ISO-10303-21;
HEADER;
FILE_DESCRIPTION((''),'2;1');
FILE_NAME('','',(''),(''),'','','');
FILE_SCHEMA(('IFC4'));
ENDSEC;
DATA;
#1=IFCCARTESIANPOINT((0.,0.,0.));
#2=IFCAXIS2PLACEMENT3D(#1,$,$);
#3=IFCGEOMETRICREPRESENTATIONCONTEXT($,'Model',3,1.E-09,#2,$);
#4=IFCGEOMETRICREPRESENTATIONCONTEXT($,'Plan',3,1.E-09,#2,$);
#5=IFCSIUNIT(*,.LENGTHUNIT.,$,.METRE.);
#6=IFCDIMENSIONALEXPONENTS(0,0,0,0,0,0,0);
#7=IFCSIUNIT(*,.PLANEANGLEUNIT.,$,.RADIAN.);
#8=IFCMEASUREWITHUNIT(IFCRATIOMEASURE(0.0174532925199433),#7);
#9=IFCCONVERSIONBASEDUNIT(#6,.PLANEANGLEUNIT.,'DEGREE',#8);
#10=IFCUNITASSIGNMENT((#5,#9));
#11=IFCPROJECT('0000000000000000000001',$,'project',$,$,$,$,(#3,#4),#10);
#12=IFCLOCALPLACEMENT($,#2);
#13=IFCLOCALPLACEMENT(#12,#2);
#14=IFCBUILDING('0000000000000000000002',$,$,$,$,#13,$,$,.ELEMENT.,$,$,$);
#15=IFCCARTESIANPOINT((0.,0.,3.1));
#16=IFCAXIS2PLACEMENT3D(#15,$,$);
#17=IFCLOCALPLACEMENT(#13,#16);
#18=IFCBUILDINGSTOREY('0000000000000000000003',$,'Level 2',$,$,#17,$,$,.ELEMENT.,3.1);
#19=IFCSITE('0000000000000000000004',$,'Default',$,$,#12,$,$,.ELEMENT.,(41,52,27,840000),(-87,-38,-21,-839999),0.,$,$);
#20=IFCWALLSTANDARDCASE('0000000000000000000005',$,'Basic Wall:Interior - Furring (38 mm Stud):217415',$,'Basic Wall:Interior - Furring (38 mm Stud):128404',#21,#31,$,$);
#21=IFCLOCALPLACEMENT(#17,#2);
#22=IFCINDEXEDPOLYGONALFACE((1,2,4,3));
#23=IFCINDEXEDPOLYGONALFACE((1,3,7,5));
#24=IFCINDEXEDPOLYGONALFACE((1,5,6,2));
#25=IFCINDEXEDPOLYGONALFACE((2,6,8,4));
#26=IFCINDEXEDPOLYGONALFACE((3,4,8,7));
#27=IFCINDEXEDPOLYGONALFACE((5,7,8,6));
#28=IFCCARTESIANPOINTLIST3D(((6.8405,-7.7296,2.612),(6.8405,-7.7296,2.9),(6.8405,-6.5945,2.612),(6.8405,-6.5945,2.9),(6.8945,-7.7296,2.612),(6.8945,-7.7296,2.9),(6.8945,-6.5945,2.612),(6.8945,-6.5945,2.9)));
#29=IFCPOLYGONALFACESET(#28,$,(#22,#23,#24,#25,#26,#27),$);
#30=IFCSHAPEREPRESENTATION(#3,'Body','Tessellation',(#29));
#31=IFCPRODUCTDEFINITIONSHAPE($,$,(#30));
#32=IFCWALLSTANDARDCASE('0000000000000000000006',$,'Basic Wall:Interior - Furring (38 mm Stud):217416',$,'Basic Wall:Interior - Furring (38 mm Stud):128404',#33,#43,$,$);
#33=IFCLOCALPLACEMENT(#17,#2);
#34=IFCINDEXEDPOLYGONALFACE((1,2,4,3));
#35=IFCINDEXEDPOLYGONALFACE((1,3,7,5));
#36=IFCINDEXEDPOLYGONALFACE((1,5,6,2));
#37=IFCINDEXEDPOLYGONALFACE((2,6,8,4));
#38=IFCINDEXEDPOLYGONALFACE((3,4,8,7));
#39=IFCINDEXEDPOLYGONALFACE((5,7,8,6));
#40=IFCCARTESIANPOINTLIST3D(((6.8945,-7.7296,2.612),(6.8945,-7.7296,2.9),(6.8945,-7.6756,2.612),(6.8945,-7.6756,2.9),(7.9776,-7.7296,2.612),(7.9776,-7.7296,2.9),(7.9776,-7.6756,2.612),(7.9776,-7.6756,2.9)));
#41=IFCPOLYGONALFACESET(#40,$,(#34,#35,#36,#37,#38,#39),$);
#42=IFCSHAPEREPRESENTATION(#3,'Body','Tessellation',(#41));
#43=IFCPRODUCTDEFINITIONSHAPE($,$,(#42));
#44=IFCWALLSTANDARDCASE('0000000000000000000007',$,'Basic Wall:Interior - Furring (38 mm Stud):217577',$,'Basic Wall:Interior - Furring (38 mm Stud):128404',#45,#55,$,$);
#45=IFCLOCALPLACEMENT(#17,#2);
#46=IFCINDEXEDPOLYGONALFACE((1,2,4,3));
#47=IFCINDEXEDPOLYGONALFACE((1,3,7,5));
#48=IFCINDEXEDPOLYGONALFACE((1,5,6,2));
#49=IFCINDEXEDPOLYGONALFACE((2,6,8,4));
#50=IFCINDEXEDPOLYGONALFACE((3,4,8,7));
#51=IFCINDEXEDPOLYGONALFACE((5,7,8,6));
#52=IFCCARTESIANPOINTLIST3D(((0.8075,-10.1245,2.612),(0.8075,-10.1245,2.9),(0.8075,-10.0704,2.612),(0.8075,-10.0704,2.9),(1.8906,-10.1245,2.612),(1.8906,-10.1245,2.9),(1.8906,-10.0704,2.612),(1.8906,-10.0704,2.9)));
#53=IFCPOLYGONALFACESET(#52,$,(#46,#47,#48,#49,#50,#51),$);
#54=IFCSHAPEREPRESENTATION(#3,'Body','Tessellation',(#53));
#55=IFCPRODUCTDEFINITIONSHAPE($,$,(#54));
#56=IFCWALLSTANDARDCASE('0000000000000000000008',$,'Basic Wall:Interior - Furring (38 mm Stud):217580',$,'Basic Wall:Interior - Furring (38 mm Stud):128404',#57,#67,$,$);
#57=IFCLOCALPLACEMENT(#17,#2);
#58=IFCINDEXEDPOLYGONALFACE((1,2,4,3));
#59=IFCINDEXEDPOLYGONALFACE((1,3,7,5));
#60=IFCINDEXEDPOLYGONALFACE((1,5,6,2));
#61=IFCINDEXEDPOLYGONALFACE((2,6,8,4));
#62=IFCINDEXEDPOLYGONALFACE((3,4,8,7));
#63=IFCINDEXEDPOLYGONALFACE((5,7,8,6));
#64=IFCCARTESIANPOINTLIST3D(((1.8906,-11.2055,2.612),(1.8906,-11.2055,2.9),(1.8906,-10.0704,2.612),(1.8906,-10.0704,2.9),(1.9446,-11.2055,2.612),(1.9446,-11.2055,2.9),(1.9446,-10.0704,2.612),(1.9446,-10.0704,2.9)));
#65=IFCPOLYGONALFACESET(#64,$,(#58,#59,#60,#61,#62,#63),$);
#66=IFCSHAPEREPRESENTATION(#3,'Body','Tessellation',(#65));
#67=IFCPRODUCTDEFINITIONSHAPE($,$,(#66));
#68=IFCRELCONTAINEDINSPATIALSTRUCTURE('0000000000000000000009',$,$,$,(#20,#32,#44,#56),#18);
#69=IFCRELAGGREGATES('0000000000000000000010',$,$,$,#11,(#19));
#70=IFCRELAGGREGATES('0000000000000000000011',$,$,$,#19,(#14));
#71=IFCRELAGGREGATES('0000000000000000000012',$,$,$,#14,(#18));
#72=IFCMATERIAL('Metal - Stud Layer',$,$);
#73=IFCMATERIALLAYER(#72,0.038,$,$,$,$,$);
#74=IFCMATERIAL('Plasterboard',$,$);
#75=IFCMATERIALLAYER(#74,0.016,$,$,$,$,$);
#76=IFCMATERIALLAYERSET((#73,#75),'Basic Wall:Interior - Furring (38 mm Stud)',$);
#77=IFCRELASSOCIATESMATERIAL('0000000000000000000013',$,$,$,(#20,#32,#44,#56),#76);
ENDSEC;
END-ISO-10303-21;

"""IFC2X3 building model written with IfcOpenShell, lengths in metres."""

from ifc_helpers import new_model, entity, si_unit, converted_unit, frame, frame_2d, origin, place, context, project, spatial, rectangle, extrude, material, layer, layer_set, layer_usage, element, save


model = new_model("IFC2X3")

# Units and contexts
model_context = context("Model", 3, precision=1e-09, world=origin())
plan_context = context("Plan", 3, precision=1e-09, world=origin())
ifc_project = project(units=[si_unit("LENGTHUNIT", "METRE"), converted_unit("PLANEANGLEUNIT", "DEGREE", entity("IfcRatioMeasure", 0.0174532925199433), si_unit("PLANEANGLEUNIT", "RADIAN"), dimensions=[0, 0, 0, 0, 0, 0, 0])], contexts=[model_context, plan_context])

# Site, building, storey
site_placement = place(None, origin())
site = spatial("IfcSite", under=ifc_project, at=site_placement, Name="Default", CompositionType="ELEMENT", RefLatitude=(41, 52, 27, 840000), RefLongitude=(-87, -38, -21, -839999), RefElevation=0.0)
building_placement = place(site_placement, origin())
building = spatial("IfcBuilding", under=site, at=building_placement, CompositionType="ELEMENT")
storey_placement = place(building_placement, frame((0.0, 0.0, 3.1)))
storey = spatial("IfcBuildingStorey", under=building, at=storey_placement, Name="Level 2", CompositionType="ELEMENT", Elevation=3.1)

# Shared definitions
ifc_material_1 = material(Name="Plasterboard")
ifc_material_2 = material(Name="Metal - Stud Layer")

# Walls
ifc_layer_1 = layer(ifc_material_2, 0.038)
ifc_layer_2 = layer(ifc_material_1, 0.016)
ifc_layer_set_1 = layer_set([ifc_layer_1, ifc_layer_2], Name="Basic Wall:Interior - Furring (38 mm Stud)")
ifc_layer_usage_1 = layer_usage(ifc_layer_set_1, "AXIS2", "NEGATIVE", 0.027)
wall_1_placement = place(storey_placement, frame((6.8675, -7.7296, 2.612), z_axis=(0.0, 0.0, 1.0), x_axis=(0.0, 1.0, 0.0)))
element("IfcWallStandardCase", 1, at=wall_1_placement, inside=storey, material=ifc_layer_usage_1, Name="Basic Wall:Interior - Furring (38 mm Stud):217415", ObjectType="Basic Wall:Interior - Furring (38 mm Stud):128404", context=model_context, shape_type="SweptSolid", body=[
    extrude(rectangle(XDim=1.1351, YDim=0.054, at=frame_2d((0.5675, 0.0), x_axis=(-1.0, 0.0))), origin(), (0.0, 0.0, 1.0), 0.288),
])
ifc_layer_usage_2 = layer_usage(ifc_layer_set_1, "AXIS2", "NEGATIVE", 0.027)
wall_2_placement = place(storey_placement, frame((7.9776, -7.7026, 2.612), z_axis=(0.0, 0.0, 1.0), x_axis=(-1.0, 0.0, 0.0)))
element("IfcWallStandardCase", 2, at=wall_2_placement, inside=storey, material=ifc_layer_usage_2, Name="Basic Wall:Interior - Furring (38 mm Stud):217416", ObjectType="Basic Wall:Interior - Furring (38 mm Stud):128404", context=model_context, shape_type="SweptSolid", body=[
    extrude(rectangle(XDim=1.0831, YDim=0.054, at=frame_2d((0.5415, 0.0), x_axis=(-1.0, 0.0))), origin(), (0.0, 0.0, 1.0), 0.288),
])
ifc_layer_usage_3 = layer_usage(ifc_layer_set_1, "AXIS2", "NEGATIVE", 0.027)
wall_3_placement = place(storey_placement, frame((0.8075, -10.0975, 2.612)))
element("IfcWallStandardCase", 3, at=wall_3_placement, inside=storey, material=ifc_layer_usage_3, Name="Basic Wall:Interior - Furring (38 mm Stud):217577", ObjectType="Basic Wall:Interior - Furring (38 mm Stud):128404", context=model_context, shape_type="SweptSolid", body=[
    extrude(rectangle(XDim=1.0831, YDim=0.054, at=frame_2d((0.5415, 0.0), x_axis=(-1.0, 0.0))), origin(), (0.0, 0.0, 1.0), 0.288),
])
ifc_layer_usage_4 = layer_usage(ifc_layer_set_1, "AXIS2", "NEGATIVE", 0.027)
wall_4_placement = place(storey_placement, frame((1.9176, -10.0704, 2.612), z_axis=(0.0, 0.0, 1.0), x_axis=(0.0, -1.0, 0.0)))
element("IfcWallStandardCase", 4, at=wall_4_placement, inside=storey, material=ifc_layer_usage_4, Name="Basic Wall:Interior - Furring (38 mm Stud):217580", ObjectType="Basic Wall:Interior - Furring (38 mm Stud):128404", context=model_context, shape_type="SweptSolid", body=[
    extrude(rectangle(XDim=1.1351, YDim=0.054, at=frame_2d((0.5675, 0.0), x_axis=(-1.0, 0.0))), origin(), (0.0, 0.0, 1.0), 0.288),
])

save(model, "model.ifc")
